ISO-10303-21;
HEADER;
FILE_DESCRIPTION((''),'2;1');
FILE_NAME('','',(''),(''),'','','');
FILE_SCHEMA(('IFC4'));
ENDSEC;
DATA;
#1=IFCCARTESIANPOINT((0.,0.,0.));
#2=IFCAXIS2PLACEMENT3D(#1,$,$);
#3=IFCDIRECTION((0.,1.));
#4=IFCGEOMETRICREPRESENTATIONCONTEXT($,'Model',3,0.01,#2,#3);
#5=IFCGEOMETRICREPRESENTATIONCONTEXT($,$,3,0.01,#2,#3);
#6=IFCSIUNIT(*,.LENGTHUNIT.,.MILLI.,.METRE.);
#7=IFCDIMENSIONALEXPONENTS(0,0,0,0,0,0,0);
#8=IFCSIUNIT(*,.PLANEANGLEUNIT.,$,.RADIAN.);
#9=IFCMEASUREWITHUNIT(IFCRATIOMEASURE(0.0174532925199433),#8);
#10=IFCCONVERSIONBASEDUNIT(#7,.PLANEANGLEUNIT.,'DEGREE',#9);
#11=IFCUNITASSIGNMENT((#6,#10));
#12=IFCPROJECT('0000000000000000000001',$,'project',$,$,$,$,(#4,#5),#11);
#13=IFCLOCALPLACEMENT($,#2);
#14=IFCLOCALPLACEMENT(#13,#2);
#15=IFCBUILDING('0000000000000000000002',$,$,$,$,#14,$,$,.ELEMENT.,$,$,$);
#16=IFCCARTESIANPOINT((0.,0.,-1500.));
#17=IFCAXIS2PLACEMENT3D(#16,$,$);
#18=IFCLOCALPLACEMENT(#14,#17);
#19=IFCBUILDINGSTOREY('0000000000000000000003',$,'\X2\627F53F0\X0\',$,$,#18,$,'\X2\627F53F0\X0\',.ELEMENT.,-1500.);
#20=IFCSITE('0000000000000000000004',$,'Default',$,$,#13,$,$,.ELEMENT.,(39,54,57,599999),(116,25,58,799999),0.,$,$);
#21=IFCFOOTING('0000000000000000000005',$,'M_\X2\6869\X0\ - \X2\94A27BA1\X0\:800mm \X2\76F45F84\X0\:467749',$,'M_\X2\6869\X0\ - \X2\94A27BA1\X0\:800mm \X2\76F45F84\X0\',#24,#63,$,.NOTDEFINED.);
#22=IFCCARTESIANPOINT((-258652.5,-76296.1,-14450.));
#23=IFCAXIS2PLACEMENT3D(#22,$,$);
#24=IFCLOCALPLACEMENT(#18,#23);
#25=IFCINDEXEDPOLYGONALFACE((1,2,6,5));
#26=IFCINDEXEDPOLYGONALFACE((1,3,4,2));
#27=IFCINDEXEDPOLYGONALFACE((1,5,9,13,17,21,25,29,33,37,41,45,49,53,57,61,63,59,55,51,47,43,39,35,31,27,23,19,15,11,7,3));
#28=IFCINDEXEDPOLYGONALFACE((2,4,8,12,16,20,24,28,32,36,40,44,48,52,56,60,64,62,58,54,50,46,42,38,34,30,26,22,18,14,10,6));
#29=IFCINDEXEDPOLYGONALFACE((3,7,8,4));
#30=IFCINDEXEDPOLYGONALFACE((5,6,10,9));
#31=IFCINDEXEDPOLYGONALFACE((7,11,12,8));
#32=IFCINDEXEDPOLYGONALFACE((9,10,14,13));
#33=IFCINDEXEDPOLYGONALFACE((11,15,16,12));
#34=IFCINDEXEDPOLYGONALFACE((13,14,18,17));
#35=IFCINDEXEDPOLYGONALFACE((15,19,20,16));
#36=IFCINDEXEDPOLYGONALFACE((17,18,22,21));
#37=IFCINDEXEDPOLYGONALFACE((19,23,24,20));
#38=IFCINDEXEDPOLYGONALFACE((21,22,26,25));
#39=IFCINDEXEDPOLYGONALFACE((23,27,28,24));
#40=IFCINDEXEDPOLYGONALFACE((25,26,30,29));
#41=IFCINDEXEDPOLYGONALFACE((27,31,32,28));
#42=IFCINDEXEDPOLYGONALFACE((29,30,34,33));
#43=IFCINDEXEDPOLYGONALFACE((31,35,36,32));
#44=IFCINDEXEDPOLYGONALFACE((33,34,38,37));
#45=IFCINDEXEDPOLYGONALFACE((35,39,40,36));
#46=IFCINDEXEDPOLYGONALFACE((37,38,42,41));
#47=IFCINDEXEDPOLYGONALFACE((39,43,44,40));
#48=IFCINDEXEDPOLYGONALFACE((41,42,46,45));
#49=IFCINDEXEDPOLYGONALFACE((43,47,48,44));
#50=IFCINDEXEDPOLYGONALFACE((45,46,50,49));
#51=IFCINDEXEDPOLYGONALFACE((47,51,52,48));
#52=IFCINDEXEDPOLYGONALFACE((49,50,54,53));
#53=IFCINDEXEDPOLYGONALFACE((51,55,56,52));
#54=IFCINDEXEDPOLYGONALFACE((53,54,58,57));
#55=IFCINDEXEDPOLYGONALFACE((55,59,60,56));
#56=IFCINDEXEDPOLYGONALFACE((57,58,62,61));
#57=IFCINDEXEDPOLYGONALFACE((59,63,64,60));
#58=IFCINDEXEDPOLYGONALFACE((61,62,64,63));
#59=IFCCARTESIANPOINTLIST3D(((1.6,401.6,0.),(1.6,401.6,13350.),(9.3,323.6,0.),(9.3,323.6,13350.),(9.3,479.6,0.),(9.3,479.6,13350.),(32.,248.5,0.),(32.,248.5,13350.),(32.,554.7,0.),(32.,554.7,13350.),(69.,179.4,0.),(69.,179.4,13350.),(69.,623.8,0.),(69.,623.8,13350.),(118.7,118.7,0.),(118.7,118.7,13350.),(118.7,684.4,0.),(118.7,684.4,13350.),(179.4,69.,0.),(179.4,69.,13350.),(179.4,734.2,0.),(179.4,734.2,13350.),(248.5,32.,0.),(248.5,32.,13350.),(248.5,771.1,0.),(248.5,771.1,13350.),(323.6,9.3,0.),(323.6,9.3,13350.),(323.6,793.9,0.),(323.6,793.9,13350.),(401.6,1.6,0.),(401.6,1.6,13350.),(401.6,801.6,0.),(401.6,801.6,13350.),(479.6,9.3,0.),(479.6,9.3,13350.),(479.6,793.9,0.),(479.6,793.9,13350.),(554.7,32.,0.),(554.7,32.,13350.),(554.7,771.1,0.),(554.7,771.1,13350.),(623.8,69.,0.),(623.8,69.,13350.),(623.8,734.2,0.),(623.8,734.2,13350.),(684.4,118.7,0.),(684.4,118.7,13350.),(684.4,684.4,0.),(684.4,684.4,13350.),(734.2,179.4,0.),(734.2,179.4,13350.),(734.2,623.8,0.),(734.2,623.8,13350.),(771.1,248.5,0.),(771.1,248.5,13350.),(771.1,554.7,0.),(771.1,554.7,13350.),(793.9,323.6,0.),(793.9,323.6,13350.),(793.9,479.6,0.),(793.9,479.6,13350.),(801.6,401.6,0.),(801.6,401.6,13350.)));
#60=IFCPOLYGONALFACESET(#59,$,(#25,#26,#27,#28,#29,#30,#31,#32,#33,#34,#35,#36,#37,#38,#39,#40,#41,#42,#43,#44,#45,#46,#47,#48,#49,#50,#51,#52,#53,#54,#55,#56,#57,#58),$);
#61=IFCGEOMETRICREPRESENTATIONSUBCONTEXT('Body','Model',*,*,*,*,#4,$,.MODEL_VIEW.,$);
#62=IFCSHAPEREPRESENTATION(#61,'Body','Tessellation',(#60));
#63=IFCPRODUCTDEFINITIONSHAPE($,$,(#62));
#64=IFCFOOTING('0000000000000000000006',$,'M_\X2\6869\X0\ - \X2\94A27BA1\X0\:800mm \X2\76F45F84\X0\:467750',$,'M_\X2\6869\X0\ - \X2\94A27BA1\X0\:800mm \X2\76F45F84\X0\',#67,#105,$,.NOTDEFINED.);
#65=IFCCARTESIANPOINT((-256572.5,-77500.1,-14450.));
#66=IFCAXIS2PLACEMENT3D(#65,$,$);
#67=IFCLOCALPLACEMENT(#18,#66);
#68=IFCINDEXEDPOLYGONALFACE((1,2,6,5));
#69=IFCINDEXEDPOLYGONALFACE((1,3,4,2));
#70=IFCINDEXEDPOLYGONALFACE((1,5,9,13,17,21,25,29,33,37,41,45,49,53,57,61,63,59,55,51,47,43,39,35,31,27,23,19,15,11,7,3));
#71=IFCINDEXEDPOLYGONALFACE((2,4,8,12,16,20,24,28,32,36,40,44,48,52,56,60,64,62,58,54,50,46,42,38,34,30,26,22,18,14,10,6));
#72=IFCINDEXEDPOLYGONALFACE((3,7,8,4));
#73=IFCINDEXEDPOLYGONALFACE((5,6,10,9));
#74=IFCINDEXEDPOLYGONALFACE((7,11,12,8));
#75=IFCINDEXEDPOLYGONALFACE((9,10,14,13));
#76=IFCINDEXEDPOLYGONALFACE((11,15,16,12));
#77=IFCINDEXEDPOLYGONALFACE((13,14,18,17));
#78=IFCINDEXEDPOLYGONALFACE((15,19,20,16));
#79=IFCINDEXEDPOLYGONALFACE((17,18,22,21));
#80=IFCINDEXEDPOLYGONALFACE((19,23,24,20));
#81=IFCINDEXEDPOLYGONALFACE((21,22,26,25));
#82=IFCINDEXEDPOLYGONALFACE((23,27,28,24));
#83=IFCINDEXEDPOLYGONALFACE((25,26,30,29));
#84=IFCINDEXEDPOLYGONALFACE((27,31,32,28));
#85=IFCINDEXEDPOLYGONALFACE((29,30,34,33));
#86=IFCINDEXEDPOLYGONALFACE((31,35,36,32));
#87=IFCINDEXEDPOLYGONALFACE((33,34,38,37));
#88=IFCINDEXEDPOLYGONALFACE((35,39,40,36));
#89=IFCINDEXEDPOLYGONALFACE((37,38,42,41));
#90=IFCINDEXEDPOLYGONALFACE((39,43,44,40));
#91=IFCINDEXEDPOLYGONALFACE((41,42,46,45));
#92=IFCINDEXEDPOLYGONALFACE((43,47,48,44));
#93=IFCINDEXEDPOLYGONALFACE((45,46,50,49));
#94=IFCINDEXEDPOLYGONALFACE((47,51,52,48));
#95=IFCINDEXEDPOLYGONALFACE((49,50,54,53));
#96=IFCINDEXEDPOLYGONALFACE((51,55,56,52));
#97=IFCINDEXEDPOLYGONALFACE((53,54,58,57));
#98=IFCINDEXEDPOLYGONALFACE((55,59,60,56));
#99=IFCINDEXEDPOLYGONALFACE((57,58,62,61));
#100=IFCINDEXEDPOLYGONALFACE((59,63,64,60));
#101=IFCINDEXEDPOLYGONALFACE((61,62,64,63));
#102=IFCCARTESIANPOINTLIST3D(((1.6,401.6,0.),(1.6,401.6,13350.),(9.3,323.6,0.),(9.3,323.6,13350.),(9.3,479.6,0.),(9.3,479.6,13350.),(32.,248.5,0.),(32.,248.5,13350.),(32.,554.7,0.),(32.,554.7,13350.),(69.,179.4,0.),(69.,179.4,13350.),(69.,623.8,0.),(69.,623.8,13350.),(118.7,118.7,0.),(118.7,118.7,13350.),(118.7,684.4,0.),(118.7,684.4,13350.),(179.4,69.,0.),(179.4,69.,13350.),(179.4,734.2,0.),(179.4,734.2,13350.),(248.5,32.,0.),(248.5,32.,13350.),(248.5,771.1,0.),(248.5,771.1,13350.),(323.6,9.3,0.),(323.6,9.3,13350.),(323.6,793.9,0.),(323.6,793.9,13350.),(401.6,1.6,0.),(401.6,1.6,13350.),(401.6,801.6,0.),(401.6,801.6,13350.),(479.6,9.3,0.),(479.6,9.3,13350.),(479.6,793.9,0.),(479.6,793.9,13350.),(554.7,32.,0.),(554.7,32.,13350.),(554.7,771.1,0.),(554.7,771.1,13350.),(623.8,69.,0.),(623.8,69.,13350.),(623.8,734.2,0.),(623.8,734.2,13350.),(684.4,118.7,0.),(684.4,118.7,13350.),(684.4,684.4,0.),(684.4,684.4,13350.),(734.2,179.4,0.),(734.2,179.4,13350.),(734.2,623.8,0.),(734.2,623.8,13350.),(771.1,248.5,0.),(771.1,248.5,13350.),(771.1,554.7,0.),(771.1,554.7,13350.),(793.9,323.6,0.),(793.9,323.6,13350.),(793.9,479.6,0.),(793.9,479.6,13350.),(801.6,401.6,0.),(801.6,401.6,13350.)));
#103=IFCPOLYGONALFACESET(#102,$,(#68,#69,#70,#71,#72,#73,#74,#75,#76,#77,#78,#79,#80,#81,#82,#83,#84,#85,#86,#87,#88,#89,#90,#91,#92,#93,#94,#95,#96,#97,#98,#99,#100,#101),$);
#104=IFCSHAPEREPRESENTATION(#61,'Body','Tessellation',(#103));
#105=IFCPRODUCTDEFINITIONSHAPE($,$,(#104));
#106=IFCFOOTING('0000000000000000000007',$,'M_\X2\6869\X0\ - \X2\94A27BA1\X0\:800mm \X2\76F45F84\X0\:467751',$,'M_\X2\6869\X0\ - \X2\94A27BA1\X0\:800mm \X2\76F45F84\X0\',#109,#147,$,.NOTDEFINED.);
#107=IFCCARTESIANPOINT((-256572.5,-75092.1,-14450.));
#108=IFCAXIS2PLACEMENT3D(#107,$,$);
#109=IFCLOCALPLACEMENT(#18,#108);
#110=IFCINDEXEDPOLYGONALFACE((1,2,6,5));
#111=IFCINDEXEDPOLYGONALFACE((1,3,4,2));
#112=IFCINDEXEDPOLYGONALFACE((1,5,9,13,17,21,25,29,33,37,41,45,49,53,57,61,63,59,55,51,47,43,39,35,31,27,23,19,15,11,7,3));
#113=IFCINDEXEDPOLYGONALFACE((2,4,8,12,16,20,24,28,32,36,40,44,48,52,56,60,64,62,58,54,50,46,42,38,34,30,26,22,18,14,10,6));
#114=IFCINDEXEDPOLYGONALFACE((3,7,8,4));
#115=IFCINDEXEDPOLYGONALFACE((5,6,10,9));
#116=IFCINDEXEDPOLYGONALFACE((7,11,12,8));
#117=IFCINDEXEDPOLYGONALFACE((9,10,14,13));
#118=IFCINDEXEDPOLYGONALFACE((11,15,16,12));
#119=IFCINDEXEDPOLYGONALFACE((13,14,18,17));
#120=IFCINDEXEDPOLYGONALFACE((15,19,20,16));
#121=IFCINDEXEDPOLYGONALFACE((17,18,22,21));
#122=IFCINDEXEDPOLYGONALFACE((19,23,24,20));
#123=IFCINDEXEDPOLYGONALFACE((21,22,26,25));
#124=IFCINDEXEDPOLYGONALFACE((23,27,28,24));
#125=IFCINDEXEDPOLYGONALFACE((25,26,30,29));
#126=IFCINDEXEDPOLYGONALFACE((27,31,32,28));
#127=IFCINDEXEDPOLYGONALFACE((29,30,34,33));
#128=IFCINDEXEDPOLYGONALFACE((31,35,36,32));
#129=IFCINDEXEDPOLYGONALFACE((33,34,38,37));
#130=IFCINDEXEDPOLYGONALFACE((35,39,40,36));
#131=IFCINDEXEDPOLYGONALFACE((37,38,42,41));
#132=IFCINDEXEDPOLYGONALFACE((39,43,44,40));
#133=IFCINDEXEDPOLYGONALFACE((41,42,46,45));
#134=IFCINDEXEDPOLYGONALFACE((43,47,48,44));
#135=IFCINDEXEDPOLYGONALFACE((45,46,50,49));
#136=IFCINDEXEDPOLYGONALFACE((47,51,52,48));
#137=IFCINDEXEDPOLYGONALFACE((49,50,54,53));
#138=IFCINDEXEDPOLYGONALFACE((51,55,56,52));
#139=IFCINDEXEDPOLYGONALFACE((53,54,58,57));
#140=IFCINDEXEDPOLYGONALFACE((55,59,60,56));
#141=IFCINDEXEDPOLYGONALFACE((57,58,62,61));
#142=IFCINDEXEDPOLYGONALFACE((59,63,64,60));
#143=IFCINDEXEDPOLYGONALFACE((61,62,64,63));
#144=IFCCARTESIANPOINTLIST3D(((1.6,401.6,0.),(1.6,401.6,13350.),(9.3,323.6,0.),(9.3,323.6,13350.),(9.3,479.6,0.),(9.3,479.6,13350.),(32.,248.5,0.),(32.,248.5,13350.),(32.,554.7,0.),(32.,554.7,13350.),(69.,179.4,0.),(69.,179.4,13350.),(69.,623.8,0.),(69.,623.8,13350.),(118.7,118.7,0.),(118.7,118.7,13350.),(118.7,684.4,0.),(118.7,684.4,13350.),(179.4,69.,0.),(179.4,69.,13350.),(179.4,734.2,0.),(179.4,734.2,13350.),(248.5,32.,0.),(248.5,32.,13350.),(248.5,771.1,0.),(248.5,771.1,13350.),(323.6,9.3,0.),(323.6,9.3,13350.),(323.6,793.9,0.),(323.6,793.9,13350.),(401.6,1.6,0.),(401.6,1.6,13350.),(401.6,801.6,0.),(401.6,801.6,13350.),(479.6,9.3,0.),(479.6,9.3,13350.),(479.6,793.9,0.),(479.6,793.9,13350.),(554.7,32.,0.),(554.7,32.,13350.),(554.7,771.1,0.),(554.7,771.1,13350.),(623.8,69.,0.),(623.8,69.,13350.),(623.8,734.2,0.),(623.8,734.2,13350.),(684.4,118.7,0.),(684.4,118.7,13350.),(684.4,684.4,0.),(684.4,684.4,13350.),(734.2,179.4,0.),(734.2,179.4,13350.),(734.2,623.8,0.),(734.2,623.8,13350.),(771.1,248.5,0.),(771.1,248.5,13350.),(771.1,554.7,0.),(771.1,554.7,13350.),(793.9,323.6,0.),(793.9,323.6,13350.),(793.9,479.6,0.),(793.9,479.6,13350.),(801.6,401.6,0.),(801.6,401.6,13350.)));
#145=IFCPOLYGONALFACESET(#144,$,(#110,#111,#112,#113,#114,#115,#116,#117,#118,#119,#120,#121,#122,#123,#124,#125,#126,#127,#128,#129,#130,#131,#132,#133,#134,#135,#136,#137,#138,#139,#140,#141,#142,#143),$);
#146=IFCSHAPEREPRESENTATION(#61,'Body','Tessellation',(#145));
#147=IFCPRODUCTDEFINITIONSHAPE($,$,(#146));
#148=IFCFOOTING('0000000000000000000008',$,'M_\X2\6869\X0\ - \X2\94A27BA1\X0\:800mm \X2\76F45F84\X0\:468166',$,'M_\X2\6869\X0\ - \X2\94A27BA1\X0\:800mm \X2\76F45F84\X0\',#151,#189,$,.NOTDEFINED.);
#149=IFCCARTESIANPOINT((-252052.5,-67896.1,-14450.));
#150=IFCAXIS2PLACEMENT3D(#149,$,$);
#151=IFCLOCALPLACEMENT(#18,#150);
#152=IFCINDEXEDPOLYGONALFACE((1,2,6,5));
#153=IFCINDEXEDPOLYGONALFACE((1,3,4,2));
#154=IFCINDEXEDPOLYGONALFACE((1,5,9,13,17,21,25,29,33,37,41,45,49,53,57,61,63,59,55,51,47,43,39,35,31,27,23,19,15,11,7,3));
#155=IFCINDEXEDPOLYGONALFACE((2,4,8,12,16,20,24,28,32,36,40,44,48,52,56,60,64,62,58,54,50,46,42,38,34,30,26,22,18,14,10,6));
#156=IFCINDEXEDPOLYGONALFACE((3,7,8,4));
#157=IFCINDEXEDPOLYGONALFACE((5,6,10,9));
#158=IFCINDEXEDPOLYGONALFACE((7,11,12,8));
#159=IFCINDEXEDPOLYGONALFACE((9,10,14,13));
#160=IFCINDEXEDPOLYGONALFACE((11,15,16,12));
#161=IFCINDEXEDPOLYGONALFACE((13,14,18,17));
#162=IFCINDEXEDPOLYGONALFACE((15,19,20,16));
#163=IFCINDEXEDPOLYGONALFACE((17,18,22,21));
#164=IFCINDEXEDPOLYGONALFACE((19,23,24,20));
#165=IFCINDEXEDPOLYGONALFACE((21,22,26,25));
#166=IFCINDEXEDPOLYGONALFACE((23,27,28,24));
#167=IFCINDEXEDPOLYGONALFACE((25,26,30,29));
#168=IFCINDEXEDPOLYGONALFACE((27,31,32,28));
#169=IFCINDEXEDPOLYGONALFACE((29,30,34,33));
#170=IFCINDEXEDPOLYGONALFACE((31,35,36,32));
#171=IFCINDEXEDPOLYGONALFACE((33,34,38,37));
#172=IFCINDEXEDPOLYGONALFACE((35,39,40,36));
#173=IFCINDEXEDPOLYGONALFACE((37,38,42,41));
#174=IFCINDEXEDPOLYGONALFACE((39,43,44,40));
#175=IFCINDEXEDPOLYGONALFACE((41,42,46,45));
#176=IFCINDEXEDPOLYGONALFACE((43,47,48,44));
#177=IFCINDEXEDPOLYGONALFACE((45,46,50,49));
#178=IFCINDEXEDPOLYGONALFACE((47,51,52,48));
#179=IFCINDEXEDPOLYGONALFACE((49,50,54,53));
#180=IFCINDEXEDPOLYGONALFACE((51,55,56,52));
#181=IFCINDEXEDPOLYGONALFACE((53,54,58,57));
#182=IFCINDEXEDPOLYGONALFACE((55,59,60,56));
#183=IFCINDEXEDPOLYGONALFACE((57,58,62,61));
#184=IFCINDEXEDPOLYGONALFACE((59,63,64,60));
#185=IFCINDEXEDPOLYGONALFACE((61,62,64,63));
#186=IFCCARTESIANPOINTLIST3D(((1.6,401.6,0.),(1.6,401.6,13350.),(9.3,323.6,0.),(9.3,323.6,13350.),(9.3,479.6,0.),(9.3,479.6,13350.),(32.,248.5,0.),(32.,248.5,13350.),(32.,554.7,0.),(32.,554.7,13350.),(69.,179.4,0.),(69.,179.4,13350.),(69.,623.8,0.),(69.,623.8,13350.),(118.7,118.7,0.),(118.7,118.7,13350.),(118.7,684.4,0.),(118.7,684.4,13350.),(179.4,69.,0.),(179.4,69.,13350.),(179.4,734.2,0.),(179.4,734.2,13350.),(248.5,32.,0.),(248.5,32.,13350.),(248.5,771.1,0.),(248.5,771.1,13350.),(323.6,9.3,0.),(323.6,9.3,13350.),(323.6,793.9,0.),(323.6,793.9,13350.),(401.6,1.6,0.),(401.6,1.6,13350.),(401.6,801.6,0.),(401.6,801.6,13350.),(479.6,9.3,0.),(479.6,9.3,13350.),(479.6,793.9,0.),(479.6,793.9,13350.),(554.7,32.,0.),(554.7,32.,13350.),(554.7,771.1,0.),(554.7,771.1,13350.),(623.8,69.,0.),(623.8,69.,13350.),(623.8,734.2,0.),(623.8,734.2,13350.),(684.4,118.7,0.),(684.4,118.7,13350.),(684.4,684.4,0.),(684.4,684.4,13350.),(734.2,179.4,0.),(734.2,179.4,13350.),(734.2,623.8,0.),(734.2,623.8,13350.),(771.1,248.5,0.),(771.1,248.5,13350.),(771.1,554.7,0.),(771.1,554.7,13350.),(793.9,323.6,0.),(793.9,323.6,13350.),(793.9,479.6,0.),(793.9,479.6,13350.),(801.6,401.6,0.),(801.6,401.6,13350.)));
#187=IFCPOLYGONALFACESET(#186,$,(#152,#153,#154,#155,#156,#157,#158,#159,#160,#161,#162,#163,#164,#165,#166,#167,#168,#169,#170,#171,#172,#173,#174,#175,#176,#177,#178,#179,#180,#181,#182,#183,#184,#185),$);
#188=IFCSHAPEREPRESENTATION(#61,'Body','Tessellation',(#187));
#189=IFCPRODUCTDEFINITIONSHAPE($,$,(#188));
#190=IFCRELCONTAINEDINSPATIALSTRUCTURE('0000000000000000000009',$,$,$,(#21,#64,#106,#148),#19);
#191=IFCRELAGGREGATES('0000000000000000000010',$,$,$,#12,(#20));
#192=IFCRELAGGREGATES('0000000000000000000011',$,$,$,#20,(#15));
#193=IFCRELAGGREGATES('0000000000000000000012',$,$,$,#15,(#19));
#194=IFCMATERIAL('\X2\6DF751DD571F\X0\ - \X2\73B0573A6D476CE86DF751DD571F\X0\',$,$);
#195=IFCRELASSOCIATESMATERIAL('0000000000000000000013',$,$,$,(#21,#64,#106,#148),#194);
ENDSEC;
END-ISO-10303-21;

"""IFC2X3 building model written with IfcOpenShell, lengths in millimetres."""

from ifc_helpers import new_model, entity, si_unit, converted_unit, direction, frame, origin, origin_2d_with_axis, place, context, subcontext, project, spatial, circle, extrude, material, element, save


model = new_model("IFC2X3")

# Units and contexts
model_context = context("Model", 3, precision=0.01, world=origin(), true_north=direction((0.0, 1.0)))
context_of_model = context(None, 3, precision=0.01, world=origin(), true_north=direction((0.0, 1.0)))
body_context = subcontext(model_context, "Body", "Model", "MODEL_VIEW")
ifc_project = project(units=[si_unit("LENGTHUNIT", "METRE", prefix="MILLI"), converted_unit("PLANEANGLEUNIT", "DEGREE", entity("IfcRatioMeasure", 0.0174532925199433), si_unit("PLANEANGLEUNIT", "RADIAN"), dimensions=[0, 0, 0, 0, 0, 0, 0])], contexts=[model_context, context_of_model])

# Site, building, storey
site_placement = place(None, origin())
site = spatial("IfcSite", under=ifc_project, at=site_placement, Name="Default", CompositionType="ELEMENT", RefLatitude=(39, 54, 57, 599999), RefLongitude=(116, 25, 58, 799999), RefElevation=0.0)
building_placement = place(site_placement, origin())
building = spatial("IfcBuilding", under=site, at=building_placement, CompositionType="ELEMENT")
storey_placement = place(building_placement, frame((0.0, 0.0, -1500.0)))
storey = spatial("IfcBuildingStorey", under=building, at=storey_placement, Name="承台", LongName="承台", CompositionType="ELEMENT", Elevation=-1500.0)

# Footings
ifc_material_1 = material(Name="混凝土 - 现场浇注混凝土")
for number, where, name in (
    (1, (-258652.5, -76296.1, -14450.0), "M_桩 - 钢管:800mm 直径:467749"),
    (2, (-256572.5, -77500.1, -14450.0), "M_桩 - 钢管:800mm 直径:467750"),
    (3, (-256572.5, -75092.1, -14450.0), "M_桩 - 钢管:800mm 直径:467751"),
):
    element("IfcFooting", number, at=place(storey_placement, frame(where)), inside=storey, material=ifc_material_1, Name=name, ObjectType="M_桩 - 钢管:800mm 直径", PredefinedType="NOTDEFINED", context=body_context, shape_type="SweptSolid", body=[
        extrude(circle(Radius=400.0, at=origin_2d_with_axis()), frame((401.6, 401.6, 0.0), z_axis=(0.0, 0.0, 1.0), x_axis=(0.0, 1.0, 0.0)), (0.0, 0.0, 1.0), 13350.0),
    ])
footing_1_placement = place(storey_placement, frame((-252052.5, -67896.1, -14450.0)))
element("IfcFooting", 4, at=footing_1_placement, inside=storey, material=ifc_material_1, Name="M_桩 - 钢管:800mm 直径:468166", ObjectType="M_桩 - 钢管:800mm 直径", PredefinedType="NOTDEFINED", context=body_context, shape_type="SweptSolid", body=[
    extrude(circle(Radius=400.0, at=origin_2d_with_axis()), frame((401.6, 401.6, 0.0), z_axis=(0.0, 0.0, 1.0), x_axis=(0.0, 1.0, 0.0)), (0.0, 0.0, 1.0), 13350.0),
])

save(model, "model.ifc")
